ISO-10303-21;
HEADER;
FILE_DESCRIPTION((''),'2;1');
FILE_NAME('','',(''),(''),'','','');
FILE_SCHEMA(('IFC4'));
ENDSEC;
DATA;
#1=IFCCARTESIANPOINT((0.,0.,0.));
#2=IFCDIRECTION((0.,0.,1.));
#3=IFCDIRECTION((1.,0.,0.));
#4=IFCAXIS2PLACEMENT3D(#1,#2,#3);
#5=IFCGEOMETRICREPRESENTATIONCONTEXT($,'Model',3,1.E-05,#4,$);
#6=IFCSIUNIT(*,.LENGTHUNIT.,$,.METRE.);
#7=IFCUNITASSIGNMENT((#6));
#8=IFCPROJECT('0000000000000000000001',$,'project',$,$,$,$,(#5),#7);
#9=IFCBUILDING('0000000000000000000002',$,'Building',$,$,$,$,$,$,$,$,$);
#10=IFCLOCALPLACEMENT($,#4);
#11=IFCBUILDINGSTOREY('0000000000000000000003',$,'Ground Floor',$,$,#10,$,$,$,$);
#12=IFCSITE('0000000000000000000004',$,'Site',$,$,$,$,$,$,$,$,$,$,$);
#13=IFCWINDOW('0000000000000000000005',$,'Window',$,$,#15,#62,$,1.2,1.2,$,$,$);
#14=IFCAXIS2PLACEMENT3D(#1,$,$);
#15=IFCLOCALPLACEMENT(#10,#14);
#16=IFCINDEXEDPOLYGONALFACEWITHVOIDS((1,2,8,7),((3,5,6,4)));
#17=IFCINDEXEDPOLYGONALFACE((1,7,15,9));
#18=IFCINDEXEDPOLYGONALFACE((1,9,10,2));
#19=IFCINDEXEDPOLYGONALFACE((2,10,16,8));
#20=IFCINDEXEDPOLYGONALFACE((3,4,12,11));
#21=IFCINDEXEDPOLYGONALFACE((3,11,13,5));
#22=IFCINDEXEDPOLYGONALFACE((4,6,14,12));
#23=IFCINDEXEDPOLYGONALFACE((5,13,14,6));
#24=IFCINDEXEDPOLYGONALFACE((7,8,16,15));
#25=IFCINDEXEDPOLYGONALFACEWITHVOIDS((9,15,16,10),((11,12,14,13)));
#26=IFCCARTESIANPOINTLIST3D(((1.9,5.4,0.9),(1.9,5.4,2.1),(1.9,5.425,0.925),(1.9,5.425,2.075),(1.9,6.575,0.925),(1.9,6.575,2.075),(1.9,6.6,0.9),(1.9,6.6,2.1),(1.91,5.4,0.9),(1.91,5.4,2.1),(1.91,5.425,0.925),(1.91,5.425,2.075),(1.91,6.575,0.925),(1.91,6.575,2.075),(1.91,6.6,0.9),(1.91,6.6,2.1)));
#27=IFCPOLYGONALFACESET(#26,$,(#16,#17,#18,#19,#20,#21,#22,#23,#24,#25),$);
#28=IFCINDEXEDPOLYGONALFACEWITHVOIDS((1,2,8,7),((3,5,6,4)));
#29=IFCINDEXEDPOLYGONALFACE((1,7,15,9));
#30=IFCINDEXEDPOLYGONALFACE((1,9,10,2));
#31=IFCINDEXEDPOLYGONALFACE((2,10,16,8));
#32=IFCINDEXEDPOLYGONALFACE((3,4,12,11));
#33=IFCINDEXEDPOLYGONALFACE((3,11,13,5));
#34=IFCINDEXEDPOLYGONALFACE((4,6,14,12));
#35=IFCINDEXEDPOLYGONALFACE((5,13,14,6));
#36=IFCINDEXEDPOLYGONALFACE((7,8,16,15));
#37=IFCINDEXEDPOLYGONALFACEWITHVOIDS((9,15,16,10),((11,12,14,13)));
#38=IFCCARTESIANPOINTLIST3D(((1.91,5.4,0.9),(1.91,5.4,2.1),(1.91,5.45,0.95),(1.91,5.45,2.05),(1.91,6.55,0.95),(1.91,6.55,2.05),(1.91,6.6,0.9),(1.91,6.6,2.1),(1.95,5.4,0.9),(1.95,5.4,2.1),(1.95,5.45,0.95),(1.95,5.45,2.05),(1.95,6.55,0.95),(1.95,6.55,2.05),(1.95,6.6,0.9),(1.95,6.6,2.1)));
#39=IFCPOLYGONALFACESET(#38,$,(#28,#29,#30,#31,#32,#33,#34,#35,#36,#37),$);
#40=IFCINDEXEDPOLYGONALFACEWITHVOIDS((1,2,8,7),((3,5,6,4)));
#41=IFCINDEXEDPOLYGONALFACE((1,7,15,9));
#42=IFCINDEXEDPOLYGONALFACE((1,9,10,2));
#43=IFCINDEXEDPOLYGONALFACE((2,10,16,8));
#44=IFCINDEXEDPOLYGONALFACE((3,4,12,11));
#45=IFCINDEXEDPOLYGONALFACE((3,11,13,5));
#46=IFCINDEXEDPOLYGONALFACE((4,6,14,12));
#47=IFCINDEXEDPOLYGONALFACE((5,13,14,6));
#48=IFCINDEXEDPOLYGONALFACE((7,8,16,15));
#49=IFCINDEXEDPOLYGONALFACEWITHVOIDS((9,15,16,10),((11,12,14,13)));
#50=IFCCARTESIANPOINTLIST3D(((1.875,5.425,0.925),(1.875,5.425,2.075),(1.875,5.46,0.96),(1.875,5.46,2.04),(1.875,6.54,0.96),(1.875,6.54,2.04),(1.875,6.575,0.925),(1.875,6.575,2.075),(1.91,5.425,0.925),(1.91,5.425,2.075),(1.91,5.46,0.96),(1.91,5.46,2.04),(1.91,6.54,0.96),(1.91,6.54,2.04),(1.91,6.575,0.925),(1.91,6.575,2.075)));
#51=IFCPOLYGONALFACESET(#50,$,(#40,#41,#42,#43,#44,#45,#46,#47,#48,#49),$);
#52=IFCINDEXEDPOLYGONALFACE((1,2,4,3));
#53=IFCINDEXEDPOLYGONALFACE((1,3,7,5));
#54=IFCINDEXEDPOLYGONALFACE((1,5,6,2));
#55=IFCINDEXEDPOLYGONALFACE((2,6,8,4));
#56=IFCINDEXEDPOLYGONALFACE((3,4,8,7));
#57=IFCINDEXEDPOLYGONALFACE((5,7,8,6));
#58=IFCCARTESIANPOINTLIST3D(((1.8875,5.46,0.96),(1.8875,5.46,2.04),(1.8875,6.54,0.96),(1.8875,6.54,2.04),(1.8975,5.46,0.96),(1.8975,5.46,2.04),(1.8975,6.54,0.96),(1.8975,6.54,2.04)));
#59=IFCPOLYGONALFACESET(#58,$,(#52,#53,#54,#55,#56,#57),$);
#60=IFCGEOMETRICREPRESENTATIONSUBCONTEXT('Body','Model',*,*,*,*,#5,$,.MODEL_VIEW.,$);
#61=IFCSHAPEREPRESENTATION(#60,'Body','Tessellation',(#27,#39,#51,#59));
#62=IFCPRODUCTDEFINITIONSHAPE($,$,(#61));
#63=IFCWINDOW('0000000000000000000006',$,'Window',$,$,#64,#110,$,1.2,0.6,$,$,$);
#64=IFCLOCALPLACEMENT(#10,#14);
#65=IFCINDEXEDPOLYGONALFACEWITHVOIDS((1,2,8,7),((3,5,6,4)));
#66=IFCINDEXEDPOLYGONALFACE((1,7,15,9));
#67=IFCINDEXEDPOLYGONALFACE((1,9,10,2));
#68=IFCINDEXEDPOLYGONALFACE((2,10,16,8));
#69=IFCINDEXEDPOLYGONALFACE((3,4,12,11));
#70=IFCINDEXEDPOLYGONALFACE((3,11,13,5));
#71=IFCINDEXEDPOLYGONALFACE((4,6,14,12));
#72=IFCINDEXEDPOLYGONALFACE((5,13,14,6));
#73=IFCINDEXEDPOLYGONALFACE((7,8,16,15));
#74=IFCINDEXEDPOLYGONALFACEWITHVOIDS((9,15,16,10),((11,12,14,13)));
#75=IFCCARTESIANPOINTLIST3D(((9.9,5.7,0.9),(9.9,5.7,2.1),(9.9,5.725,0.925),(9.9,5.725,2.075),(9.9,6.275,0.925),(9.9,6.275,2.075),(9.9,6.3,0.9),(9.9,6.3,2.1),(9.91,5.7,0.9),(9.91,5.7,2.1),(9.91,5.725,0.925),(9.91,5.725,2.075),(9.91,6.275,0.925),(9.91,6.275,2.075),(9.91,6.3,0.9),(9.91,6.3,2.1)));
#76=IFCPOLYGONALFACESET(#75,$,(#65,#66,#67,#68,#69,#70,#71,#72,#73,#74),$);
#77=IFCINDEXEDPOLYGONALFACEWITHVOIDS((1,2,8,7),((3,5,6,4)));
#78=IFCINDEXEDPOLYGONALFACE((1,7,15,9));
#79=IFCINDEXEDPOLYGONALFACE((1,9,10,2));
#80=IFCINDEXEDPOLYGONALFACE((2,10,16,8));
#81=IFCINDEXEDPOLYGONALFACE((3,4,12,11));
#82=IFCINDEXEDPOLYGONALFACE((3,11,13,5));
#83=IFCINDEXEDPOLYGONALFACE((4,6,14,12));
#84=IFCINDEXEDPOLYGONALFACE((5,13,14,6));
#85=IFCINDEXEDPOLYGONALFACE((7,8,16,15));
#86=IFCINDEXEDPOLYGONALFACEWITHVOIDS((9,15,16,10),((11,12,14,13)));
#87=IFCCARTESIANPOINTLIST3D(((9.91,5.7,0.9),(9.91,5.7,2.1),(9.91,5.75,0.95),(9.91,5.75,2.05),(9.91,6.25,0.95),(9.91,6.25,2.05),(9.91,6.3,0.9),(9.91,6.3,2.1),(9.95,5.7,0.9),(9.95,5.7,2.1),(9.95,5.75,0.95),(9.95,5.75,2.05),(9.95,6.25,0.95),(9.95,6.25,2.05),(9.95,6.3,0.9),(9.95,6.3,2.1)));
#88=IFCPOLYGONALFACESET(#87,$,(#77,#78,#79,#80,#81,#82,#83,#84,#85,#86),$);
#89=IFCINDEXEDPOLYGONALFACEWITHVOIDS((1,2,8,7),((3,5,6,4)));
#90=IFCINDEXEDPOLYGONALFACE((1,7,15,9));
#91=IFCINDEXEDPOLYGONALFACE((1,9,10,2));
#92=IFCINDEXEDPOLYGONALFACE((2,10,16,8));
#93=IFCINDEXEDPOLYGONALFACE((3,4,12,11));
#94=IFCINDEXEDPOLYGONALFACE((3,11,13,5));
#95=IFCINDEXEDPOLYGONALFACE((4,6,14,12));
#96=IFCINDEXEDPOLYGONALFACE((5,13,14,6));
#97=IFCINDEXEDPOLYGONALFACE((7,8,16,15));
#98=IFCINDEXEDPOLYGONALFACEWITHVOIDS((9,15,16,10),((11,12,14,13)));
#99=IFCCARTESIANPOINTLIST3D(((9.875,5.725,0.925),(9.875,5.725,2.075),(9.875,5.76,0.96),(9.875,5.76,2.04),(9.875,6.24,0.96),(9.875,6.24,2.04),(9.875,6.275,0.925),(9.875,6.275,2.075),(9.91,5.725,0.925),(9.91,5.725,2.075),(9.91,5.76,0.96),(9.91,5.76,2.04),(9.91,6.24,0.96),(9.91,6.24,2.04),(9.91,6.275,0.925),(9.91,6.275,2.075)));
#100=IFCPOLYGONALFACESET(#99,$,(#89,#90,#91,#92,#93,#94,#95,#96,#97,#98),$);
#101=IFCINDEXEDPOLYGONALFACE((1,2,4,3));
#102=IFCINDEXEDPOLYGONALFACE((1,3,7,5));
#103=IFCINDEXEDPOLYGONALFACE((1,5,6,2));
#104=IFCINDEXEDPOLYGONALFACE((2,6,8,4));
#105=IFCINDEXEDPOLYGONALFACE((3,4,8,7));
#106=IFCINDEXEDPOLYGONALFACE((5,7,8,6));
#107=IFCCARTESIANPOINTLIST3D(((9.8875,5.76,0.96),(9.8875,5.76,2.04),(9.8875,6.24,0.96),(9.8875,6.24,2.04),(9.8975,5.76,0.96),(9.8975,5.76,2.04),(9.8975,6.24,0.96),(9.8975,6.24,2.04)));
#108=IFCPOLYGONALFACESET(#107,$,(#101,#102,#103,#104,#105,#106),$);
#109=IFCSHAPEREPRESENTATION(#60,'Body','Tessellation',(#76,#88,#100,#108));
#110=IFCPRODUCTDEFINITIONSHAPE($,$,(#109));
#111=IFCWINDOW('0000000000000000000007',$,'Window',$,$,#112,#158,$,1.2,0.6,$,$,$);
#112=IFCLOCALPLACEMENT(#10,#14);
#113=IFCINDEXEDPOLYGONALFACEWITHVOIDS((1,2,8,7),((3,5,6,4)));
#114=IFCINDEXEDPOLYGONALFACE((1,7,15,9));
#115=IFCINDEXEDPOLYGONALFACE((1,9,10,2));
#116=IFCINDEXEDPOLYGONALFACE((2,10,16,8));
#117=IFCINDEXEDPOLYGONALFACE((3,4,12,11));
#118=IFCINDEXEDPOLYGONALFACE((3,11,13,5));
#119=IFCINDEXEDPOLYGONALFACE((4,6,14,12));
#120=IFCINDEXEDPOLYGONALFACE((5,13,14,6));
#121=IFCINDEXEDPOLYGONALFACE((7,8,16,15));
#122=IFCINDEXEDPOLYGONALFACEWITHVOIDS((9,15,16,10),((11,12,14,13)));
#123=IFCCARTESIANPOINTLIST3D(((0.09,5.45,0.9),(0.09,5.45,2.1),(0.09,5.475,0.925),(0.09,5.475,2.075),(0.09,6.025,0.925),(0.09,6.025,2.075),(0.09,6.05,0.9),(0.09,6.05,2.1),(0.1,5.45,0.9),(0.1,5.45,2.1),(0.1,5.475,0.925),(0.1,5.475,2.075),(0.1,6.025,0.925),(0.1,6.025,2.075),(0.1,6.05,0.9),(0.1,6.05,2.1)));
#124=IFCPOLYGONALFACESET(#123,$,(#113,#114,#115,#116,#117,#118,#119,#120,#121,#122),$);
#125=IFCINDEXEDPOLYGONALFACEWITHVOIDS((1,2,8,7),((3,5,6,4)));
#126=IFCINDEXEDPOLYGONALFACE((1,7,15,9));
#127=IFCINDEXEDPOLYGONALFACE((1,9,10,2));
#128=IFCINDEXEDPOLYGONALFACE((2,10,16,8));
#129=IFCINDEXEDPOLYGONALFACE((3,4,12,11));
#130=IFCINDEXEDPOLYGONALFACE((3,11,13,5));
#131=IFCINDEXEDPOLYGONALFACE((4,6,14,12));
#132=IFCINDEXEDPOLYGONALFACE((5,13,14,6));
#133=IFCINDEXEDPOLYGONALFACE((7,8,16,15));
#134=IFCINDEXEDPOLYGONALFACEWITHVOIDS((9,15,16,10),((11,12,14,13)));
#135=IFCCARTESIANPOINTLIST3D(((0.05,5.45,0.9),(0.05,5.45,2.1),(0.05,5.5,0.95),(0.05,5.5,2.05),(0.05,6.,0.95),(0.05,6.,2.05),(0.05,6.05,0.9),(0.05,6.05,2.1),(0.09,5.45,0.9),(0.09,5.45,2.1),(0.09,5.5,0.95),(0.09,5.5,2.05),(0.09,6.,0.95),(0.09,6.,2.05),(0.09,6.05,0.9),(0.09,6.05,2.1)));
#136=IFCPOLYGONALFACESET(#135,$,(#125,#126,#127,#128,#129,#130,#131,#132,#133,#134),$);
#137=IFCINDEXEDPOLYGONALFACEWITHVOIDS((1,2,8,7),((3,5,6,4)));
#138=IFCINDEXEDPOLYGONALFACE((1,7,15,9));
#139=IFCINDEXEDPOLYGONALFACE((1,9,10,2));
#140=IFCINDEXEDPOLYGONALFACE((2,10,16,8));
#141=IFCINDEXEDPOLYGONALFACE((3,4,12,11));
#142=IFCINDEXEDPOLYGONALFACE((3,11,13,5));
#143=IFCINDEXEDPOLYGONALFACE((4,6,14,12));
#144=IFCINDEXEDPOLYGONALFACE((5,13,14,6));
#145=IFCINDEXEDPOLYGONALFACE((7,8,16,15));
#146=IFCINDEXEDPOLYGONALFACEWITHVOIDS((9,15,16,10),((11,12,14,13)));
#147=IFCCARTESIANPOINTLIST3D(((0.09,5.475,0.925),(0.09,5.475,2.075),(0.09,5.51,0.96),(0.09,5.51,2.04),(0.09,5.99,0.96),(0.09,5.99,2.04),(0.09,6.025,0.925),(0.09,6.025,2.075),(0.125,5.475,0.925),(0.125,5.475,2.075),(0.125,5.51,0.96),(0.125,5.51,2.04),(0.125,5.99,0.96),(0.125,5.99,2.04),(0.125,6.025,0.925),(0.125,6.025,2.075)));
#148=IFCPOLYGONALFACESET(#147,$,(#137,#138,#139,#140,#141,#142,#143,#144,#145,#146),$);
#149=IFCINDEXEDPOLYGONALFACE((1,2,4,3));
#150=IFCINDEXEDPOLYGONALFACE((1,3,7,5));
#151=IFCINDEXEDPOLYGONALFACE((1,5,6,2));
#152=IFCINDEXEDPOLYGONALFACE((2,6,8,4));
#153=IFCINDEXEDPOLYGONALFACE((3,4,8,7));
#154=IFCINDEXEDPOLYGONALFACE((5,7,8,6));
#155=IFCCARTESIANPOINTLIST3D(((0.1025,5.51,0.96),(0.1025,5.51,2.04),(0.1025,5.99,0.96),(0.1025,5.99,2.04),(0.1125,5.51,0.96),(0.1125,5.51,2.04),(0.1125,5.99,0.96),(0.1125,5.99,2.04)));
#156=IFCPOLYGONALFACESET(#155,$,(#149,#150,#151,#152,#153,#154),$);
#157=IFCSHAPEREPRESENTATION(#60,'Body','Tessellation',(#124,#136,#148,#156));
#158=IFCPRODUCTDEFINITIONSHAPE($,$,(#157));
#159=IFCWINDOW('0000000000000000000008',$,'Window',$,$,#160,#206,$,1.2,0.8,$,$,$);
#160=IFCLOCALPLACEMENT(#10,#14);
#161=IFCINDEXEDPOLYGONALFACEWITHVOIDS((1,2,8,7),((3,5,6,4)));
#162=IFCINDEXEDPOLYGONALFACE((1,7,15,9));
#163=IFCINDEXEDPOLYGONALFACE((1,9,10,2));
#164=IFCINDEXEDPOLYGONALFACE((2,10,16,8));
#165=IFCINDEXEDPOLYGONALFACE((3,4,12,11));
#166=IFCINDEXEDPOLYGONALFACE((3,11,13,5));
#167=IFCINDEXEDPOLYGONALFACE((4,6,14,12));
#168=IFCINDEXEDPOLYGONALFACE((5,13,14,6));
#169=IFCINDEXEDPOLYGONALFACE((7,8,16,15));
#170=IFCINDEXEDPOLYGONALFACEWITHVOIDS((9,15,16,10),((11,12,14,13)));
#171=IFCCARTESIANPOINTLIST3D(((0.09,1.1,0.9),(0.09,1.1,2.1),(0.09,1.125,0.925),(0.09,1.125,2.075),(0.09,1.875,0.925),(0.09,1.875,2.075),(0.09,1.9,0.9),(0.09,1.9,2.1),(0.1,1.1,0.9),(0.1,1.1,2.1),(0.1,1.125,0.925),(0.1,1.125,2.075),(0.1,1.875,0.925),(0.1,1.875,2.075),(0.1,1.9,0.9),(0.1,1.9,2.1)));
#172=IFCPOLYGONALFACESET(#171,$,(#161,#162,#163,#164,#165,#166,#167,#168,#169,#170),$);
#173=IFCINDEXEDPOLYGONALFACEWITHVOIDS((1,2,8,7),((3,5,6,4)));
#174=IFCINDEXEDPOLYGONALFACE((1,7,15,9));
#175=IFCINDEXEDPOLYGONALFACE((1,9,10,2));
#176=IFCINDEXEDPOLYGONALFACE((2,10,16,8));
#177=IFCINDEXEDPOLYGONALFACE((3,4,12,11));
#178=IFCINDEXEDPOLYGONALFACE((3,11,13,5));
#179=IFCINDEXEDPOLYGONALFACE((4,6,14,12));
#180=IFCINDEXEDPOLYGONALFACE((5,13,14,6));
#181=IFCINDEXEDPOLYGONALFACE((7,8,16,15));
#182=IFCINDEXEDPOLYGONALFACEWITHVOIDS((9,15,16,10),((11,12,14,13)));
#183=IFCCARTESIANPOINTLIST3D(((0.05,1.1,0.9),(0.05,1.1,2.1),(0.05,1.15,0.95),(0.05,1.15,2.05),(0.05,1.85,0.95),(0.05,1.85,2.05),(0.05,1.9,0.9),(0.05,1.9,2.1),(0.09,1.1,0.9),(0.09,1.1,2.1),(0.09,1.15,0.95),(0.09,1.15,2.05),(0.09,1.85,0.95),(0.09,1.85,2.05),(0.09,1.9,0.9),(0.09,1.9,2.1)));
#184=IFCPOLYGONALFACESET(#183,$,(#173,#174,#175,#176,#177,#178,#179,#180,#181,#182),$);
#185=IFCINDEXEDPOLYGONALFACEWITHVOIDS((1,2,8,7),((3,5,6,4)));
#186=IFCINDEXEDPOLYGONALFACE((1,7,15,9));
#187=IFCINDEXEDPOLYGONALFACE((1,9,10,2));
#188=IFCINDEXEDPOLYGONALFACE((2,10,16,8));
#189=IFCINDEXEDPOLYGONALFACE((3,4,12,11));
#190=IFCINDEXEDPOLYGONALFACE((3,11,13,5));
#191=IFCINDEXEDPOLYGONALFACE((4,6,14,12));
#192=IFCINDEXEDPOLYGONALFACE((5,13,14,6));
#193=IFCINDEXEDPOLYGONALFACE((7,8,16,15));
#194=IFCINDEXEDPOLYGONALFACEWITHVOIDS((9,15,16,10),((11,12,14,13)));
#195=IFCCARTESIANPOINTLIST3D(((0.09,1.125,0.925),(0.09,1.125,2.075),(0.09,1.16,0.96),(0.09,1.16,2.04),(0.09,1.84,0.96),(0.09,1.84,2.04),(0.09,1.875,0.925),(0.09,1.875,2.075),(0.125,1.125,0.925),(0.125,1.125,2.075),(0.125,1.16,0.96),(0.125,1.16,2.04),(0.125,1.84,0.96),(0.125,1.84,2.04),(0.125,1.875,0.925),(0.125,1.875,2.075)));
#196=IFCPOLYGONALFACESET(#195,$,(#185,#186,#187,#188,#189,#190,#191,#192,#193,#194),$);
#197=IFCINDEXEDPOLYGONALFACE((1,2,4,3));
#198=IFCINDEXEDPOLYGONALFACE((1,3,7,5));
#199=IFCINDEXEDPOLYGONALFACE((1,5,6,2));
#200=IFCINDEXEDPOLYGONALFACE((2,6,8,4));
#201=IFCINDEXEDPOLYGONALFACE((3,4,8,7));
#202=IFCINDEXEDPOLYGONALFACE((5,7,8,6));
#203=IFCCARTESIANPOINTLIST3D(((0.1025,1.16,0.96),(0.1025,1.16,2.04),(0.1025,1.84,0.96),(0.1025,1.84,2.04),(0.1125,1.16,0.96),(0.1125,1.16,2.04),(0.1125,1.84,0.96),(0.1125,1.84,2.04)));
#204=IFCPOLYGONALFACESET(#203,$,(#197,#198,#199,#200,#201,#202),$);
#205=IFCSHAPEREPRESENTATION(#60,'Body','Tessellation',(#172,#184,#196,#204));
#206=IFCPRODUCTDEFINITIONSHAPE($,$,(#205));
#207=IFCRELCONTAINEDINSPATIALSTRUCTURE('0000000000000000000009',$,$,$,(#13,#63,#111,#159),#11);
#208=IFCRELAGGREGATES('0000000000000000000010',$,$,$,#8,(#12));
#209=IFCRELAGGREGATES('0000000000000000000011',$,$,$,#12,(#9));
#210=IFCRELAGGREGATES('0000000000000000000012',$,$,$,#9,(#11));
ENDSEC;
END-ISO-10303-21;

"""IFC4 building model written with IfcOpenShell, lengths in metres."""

from ifc_helpers import new_model, si_unit, frame, origin_with_axes, place, context, subcontext, project, spatial, line, indexed_curve, outline, extrude, element, save


model = new_model("IFC4")

# Units and contexts
model_context = context("Model", 3, precision=1e-05, world=origin_with_axes())
body_context = subcontext(model_context, "Body", "Model", "MODEL_VIEW")
ifc_project = project(units=[si_unit("LENGTHUNIT", "METRE")], contexts=[model_context])

# Site, building, storey
site = spatial("IfcSite", under=ifc_project, Name="Site")
building = spatial("IfcBuilding", under=site, Name="Building")
storey_placement = place(None, origin_with_axes())
storey = spatial("IfcBuildingStorey", under=building, at=storey_placement, Name="Ground Floor")

# Windows
window_1_placement = place(storey_placement, frame((2.0, 5.4, 0.9), z_axis=(0.0, 0.0, 1.0), x_axis=(0.0, 1.0, 0.0)))
element("IfcWindow", 1, at=window_1_placement, inside=storey, Name="Window", OverallHeight=1.2, OverallWidth=1.2, context=body_context, shape_type="SweptSolid", body=[
    extrude(outline(indexed_curve([(0.0, 0.0), (1.2, 0.0), (1.2, 1.2), (0.0, 1.2)], segments=[line(1, 2, 3, 4, 1)]), holes=[indexed_curve([(0.025, 0.025), (1.175, 0.025), (1.175, 1.175), (0.025, 1.175)], segments=[line(1, 2, 3, 4, 1)])]), frame((0.0, 0.09, 0.0), z_axis=(0.0, -1.0, 0.0), x_axis=(1.0, 0.0, 0.0)), (0.0, 0.0, -1.0), 0.01),
    extrude(outline(indexed_curve([(0.0, 0.0), (1.2, 0.0), (1.2, 1.2), (0.0, 1.2)], segments=[line(1, 2, 3, 4, 1)]), holes=[indexed_curve([(0.05, 0.05), (1.15, 0.05), (1.15, 1.15), (0.05, 1.15)], segments=[line(1, 2, 3, 4, 1)])]), frame((0.0, 0.05, 0.0), z_axis=(0.0, -1.0, 0.0), x_axis=(1.0, 0.0, 0.0)), (0.0, 0.0, -1.0), 0.04),
    extrude(outline(indexed_curve([(0.0, 0.0), (1.15, 0.0), (1.15, 1.15), (0.0, 1.15)], segments=[line(1, 2, 3, 4, 1)]), holes=[indexed_curve([(0.035, 0.035), (1.115, 0.035), (1.115, 1.115), (0.035, 1.115)], segments=[line(1, 2, 3, 4, 1)])]), frame((0.025, 0.09, 0.025), z_axis=(0.0, -1.0, 0.0), x_axis=(1.0, 0.0, 0.0)), (0.0, 0.0, -1.0), 0.035),
    extrude(outline(indexed_curve([(0.035, 0.035), (1.115, 0.035), (1.115, 1.115), (0.035, 1.115)], segments=[line(1, 2, 3, 4, 1)])), frame((0.025, 0.1025, 0.025), z_axis=(0.0, -1.0, 0.0), x_axis=(1.0, 0.0, 0.0)), (0.0, 0.0, -1.0), 0.01),
])
for number, where, z_axis, x_axis, name in (
    (2, (10.0, 5.7, 0.9), (0.0, 0.0, 1.0), (0.0, 1.0, 0.0), "Window"),
    (3, (0.0, 6.05, 0.9), (0.0, 0.0, 1.0), (0.0, -1.0, 0.0), "Window"),
):
    element("IfcWindow", number, at=place(storey_placement, frame(where, z_axis=z_axis, x_axis=x_axis)), inside=storey, Name=name, OverallHeight=1.2, OverallWidth=0.6, context=body_context, shape_type="SweptSolid", body=[
        extrude(outline(indexed_curve([(0.0, 0.0), (0.6, 0.0), (0.6, 1.2), (0.0, 1.2)], segments=[line(1, 2, 3, 4, 1)]), holes=[indexed_curve([(0.025, 0.025), (0.575, 0.025), (0.575, 1.175), (0.025, 1.175)], segments=[line(1, 2, 3, 4, 1)])]), frame((0.0, 0.09, 0.0), z_axis=(0.0, -1.0, 0.0), x_axis=(1.0, 0.0, 0.0)), (0.0, 0.0, -1.0), 0.01),
        extrude(outline(indexed_curve([(0.0, 0.0), (0.6, 0.0), (0.6, 1.2), (0.0, 1.2)], segments=[line(1, 2, 3, 4, 1)]), holes=[indexed_curve([(0.05, 0.05), (0.55, 0.05), (0.55, 1.15), (0.05, 1.15)], segments=[line(1, 2, 3, 4, 1)])]), frame((0.0, 0.05, 0.0), z_axis=(0.0, -1.0, 0.0), x_axis=(1.0, 0.0, 0.0)), (0.0, 0.0, -1.0), 0.04),
        extrude(outline(indexed_curve([(0.0, 0.0), (0.55, 0.0), (0.55, 1.15), (0.0, 1.15)], segments=[line(1, 2, 3, 4, 1)]), holes=[indexed_curve([(0.035, 0.035), (0.515, 0.035), (0.515, 1.115), (0.035, 1.115)], segments=[line(1, 2, 3, 4, 1)])]), frame((0.025, 0.09, 0.025), z_axis=(0.0, -1.0, 0.0), x_axis=(1.0, 0.0, 0.0)), (0.0, 0.0, -1.0), 0.035),
        extrude(outline(indexed_curve([(0.035, 0.035), (0.515, 0.035), (0.515, 1.115), (0.035, 1.115)], segments=[line(1, 2, 3, 4, 1)])), frame((0.025, 0.1025, 0.025), z_axis=(0.0, -1.0, 0.0), x_axis=(1.0, 0.0, 0.0)), (0.0, 0.0, -1.0), 0.01),
    ])
window_2_placement = place(storey_placement, frame((0.0, 1.9, 0.9), z_axis=(0.0, 0.0, 1.0), x_axis=(0.0, -1.0, 0.0)))
element("IfcWindow", 4, at=window_2_placement, inside=storey, Name="Window", OverallHeight=1.2, OverallWidth=0.8, context=body_context, shape_type="SweptSolid", body=[
    extrude(outline(indexed_curve([(0.0, 0.0), (0.8, 0.0), (0.8, 1.2), (0.0, 1.2)], segments=[line(1, 2, 3, 4, 1)]), holes=[indexed_curve([(0.025, 0.025), (0.775, 0.025), (0.775, 1.175), (0.025, 1.175)], segments=[line(1, 2, 3, 4, 1)])]), frame((0.0, 0.09, 0.0), z_axis=(0.0, -1.0, 0.0), x_axis=(1.0, 0.0, 0.0)), (0.0, 0.0, -1.0), 0.01),
    extrude(outline(indexed_curve([(0.0, 0.0), (0.8, 0.0), (0.8, 1.2), (0.0, 1.2)], segments=[line(1, 2, 3, 4, 1)]), holes=[indexed_curve([(0.05, 0.05), (0.75, 0.05), (0.75, 1.15), (0.05, 1.15)], segments=[line(1, 2, 3, 4, 1)])]), frame((0.0, 0.05, 0.0), z_axis=(0.0, -1.0, 0.0), x_axis=(1.0, 0.0, 0.0)), (0.0, 0.0, -1.0), 0.04),
    extrude(outline(indexed_curve([(0.0, 0.0), (0.75, 0.0), (0.75, 1.15), (0.0, 1.15)], segments=[line(1, 2, 3, 4, 1)]), holes=[indexed_curve([(0.035, 0.035), (0.715, 0.035), (0.715, 1.115), (0.035, 1.115)], segments=[line(1, 2, 3, 4, 1)])]), frame((0.025, 0.09, 0.025), z_axis=(0.0, -1.0, 0.0), x_axis=(1.0, 0.0, 0.0)), (0.0, 0.0, -1.0), 0.035),
    extrude(outline(indexed_curve([(0.035, 0.035), (0.715, 0.035), (0.715, 1.115), (0.035, 1.115)], segments=[line(1, 2, 3, 4, 1)])), frame((0.025, 0.1025, 0.025), z_axis=(0.0, -1.0, 0.0), x_axis=(1.0, 0.0, 0.0)), (0.0, 0.0, -1.0), 0.01),
])

save(model, "model.ifc")
